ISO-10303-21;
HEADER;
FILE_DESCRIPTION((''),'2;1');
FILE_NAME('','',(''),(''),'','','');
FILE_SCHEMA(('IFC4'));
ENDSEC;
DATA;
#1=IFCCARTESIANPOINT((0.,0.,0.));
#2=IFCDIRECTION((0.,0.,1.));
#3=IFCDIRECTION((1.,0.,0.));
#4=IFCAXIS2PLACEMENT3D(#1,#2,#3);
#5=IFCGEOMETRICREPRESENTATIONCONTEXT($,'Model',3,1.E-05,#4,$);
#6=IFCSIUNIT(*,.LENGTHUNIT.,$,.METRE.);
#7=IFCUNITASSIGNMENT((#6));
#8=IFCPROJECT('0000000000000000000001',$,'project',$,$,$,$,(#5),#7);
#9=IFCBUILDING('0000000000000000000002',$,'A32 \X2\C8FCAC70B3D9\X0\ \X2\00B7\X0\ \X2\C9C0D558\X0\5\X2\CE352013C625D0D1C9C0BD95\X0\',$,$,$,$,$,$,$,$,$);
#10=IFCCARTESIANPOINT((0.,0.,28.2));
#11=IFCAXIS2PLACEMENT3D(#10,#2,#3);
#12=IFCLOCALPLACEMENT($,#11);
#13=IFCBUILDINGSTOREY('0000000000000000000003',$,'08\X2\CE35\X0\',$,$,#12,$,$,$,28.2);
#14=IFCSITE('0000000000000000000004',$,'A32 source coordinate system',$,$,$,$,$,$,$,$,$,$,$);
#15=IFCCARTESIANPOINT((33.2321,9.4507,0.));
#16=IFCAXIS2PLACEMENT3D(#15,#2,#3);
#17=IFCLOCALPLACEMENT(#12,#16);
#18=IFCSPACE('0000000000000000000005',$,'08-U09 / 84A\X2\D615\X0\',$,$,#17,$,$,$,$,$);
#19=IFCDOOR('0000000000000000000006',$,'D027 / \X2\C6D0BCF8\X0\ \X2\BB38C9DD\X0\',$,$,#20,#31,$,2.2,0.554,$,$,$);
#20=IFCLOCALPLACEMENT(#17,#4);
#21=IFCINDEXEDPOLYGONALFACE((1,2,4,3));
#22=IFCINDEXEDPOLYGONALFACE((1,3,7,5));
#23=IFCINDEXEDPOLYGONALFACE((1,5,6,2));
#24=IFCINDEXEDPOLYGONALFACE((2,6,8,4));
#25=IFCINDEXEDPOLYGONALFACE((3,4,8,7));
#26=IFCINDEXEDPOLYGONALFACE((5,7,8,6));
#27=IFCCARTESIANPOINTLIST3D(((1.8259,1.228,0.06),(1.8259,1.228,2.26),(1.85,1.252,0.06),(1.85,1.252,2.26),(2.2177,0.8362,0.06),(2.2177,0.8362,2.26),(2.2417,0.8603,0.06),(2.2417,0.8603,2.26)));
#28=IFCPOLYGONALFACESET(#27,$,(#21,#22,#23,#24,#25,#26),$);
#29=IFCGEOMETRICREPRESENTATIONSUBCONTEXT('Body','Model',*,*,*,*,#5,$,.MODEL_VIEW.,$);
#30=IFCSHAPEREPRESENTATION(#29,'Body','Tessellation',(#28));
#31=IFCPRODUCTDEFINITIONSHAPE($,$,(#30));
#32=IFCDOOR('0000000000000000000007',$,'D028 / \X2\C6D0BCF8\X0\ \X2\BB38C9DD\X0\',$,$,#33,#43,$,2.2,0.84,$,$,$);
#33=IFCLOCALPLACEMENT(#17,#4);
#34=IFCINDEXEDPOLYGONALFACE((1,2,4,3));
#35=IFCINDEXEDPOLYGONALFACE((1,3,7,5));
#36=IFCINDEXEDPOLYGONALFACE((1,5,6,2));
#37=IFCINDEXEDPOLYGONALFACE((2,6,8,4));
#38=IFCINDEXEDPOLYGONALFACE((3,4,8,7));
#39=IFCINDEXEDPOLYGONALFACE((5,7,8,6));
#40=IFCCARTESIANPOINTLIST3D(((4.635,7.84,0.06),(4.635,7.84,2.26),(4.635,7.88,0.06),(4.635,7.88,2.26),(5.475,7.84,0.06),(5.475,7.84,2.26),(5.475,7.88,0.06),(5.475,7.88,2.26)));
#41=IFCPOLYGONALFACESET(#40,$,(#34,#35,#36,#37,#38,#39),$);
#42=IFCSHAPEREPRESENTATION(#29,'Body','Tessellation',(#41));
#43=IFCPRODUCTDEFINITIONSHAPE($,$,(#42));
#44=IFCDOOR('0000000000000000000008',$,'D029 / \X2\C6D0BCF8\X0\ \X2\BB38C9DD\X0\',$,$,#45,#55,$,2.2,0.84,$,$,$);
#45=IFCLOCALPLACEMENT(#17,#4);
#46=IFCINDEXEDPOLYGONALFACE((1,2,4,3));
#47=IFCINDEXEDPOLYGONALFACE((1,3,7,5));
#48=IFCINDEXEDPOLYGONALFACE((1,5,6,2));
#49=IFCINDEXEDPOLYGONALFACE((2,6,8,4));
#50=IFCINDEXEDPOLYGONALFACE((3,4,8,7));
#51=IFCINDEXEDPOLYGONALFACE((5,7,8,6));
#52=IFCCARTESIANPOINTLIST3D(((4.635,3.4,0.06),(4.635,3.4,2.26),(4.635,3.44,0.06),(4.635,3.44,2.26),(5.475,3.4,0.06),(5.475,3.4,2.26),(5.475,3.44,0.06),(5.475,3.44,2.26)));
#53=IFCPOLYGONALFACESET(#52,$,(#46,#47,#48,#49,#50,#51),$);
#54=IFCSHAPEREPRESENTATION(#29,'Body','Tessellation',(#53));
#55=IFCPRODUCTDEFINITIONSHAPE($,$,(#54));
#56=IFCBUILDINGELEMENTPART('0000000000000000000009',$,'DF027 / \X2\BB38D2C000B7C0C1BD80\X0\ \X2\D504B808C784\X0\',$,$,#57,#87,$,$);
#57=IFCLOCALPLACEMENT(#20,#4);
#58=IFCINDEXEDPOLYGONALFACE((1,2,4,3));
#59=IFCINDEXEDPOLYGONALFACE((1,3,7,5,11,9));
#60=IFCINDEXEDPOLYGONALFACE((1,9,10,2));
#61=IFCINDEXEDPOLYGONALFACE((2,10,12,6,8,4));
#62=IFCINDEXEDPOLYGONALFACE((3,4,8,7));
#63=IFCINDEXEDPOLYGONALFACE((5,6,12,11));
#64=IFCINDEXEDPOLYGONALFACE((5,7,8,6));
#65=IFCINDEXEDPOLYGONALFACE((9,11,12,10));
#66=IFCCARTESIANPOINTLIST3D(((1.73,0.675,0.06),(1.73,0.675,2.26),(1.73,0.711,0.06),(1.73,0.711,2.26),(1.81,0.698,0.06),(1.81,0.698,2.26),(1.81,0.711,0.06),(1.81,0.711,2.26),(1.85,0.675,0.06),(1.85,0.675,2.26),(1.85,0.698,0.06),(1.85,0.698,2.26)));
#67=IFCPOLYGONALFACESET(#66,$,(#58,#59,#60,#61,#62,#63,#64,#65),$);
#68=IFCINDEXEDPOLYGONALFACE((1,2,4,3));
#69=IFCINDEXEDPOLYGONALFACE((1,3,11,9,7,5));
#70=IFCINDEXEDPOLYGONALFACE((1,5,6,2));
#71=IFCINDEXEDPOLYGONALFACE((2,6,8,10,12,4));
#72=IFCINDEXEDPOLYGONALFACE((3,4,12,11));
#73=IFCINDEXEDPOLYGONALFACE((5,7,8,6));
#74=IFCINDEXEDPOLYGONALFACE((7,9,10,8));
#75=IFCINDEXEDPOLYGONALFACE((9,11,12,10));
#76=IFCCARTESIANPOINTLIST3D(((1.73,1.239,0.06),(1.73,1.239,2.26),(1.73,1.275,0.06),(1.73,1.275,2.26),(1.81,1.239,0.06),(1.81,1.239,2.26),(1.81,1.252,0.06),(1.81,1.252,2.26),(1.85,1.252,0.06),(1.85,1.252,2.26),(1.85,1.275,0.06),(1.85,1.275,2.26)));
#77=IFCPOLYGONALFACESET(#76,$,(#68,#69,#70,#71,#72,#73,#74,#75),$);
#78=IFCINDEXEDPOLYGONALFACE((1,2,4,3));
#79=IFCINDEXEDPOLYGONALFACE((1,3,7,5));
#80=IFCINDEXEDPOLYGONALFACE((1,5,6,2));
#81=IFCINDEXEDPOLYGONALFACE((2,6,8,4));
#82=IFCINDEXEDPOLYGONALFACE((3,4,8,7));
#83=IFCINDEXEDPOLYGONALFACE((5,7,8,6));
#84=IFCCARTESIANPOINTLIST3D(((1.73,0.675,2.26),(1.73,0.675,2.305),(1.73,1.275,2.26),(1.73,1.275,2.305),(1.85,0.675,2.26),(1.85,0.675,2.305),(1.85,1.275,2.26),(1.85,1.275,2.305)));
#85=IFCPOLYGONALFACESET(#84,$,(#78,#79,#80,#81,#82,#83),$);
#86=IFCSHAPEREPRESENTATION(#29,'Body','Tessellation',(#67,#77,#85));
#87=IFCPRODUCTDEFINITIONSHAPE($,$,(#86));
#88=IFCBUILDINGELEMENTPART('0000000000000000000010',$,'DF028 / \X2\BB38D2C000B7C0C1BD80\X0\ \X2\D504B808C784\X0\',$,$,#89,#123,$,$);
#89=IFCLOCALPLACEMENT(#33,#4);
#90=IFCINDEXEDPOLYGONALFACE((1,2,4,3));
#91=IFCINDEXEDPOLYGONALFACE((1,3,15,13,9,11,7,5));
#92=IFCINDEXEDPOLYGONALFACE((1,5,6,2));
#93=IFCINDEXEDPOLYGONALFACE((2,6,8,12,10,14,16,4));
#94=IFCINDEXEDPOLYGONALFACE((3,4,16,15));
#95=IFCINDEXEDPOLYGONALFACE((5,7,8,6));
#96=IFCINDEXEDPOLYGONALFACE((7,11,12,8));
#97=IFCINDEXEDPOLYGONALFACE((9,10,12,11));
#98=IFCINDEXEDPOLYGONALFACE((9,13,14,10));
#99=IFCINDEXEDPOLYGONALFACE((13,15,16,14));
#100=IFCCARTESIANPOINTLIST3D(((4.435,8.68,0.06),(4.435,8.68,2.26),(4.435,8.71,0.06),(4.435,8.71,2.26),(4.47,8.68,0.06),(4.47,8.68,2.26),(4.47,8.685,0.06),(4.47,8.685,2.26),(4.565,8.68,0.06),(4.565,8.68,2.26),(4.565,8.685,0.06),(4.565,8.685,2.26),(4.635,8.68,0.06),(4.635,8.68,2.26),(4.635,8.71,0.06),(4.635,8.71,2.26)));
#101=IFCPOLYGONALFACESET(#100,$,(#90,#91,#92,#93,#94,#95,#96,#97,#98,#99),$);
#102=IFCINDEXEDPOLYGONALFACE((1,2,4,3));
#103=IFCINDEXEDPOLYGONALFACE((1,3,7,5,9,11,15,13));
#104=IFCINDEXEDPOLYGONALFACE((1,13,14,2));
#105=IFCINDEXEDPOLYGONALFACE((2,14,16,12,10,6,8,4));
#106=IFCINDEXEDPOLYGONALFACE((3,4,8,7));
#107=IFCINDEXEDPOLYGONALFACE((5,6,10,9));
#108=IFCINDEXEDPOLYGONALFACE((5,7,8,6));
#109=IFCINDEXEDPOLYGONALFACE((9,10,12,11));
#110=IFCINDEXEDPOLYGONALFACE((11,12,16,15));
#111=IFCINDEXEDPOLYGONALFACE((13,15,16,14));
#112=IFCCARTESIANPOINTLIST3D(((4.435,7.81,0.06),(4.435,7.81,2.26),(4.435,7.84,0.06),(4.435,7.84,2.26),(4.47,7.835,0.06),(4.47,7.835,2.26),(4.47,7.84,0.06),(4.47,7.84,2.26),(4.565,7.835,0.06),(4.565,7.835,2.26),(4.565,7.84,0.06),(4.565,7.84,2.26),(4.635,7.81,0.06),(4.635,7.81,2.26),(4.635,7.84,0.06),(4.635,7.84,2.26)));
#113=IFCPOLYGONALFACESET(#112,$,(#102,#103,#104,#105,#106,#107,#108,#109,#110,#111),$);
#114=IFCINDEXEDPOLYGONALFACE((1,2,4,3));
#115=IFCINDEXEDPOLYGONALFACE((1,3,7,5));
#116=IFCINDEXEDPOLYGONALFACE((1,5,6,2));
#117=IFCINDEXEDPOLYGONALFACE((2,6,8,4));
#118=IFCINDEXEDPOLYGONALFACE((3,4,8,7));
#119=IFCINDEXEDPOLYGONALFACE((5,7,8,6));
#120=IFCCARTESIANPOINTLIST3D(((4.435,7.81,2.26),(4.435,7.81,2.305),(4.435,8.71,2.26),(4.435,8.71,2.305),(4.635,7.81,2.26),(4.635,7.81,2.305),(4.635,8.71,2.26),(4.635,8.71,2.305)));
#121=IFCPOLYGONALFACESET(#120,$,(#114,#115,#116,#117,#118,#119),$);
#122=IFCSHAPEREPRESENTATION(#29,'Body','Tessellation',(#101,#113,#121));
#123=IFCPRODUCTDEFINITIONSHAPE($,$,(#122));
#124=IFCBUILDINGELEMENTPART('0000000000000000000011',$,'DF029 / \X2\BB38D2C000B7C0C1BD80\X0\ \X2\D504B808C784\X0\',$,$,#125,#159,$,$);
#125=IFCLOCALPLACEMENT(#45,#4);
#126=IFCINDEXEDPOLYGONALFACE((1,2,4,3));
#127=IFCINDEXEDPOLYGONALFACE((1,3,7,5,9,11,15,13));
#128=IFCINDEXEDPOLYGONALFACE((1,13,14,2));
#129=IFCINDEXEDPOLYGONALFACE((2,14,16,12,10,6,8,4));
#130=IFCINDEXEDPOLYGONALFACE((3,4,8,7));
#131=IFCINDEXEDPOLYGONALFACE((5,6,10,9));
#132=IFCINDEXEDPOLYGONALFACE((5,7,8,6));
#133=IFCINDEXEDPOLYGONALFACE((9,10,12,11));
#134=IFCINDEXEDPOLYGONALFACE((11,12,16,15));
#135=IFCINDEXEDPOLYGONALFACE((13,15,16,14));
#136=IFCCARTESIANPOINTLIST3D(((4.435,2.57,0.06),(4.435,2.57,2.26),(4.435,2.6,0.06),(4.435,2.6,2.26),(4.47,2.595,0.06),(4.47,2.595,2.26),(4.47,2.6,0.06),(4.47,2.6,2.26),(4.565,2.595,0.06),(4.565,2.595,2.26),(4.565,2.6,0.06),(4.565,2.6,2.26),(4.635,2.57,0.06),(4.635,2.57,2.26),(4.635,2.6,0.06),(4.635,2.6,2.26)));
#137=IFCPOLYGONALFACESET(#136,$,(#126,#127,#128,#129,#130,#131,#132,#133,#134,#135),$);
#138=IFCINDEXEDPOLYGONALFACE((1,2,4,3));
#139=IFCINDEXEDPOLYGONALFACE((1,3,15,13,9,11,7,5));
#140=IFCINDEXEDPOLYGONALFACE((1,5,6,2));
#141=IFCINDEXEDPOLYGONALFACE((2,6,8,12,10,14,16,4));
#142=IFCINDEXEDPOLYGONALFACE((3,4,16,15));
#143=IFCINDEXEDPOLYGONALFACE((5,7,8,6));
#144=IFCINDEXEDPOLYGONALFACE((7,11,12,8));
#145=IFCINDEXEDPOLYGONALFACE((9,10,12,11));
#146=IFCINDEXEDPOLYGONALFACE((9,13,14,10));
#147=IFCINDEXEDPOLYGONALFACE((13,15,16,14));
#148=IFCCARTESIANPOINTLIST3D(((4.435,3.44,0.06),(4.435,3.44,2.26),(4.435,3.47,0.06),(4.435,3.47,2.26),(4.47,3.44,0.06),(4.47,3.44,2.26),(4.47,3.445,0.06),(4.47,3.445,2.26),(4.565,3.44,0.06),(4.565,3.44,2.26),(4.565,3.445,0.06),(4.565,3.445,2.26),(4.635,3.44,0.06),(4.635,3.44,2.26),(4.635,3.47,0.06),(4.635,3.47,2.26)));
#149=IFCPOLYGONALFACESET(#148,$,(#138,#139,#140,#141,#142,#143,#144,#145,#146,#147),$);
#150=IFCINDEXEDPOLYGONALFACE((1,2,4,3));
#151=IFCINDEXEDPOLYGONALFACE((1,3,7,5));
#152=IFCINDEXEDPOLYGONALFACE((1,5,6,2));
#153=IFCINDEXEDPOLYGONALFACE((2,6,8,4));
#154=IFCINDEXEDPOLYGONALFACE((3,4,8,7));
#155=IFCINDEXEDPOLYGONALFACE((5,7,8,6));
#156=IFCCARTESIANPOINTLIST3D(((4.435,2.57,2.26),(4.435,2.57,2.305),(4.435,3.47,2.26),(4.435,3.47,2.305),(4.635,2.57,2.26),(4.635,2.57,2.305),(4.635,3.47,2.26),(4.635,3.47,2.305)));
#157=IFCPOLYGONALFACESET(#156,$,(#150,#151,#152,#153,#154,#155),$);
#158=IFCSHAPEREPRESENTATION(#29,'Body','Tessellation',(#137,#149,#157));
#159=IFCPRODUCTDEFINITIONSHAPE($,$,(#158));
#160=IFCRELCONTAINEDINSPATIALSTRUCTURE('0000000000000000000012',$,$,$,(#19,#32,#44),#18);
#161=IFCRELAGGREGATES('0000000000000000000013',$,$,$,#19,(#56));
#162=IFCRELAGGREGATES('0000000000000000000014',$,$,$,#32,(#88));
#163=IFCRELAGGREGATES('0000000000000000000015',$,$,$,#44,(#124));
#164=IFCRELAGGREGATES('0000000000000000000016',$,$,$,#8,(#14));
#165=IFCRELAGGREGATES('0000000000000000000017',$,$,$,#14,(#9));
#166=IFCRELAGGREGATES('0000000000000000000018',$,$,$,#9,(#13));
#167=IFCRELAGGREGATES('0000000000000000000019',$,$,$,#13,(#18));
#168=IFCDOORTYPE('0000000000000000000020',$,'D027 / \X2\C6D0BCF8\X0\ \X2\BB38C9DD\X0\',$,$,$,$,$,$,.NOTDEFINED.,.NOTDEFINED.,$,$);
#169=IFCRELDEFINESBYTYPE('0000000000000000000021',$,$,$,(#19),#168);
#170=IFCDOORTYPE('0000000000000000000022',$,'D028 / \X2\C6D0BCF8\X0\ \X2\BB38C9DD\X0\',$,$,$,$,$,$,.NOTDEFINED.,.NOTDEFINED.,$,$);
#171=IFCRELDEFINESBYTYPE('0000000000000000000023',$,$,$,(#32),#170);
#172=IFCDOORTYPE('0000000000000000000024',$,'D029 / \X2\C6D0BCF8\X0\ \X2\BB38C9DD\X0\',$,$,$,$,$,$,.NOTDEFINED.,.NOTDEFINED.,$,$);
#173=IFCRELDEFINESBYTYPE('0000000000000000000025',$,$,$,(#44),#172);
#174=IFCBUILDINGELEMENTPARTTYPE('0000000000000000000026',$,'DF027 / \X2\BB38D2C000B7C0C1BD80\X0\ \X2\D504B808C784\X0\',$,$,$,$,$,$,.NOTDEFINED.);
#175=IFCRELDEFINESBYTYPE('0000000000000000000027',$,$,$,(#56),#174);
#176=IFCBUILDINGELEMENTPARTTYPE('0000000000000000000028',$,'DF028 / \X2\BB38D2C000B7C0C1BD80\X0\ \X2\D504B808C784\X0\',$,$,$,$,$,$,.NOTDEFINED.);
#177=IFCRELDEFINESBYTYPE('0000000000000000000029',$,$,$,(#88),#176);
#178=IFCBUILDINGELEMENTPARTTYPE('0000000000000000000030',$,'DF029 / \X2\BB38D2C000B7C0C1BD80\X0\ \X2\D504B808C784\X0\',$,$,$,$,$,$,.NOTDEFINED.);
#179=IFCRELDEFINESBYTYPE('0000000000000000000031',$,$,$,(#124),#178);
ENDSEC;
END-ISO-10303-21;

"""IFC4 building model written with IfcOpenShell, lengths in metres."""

from ifc_helpers import new_model, si_unit, frame, origin, origin_with_axes, place, context, subcontext, project, spatial, polyline, outline, extrude, source, transform, mapped, type_object, type_shapes, element, aggregate, save


model = new_model("IFC4")

# Units and contexts
model_context = context("Model", 3, precision=1e-05, world=origin_with_axes())
body_context = subcontext(model_context, "Body", "Model", "MODEL_VIEW")
ifc_project = project(units=[si_unit("LENGTHUNIT", "METRE")], contexts=[model_context])

# Site, building, storey, space
storey_placement = place(None, frame((0.0, 0.0, 28.2), z_axis=(0.0, 0.0, 1.0), x_axis=(1.0, 0.0, 0.0)))
space_placement = place(storey_placement, frame((33.2321, 9.4507, 0.0), z_axis=(0.0, 0.0, 1.0), x_axis=(1.0, 0.0, 0.0)))
site = spatial("IfcSite", under=ifc_project, Name="A32 source coordinate system")
building = spatial("IfcBuilding", under=site, Name="A32 주거동 · 지하5층–옥탑지붕")
storey = spatial("IfcBuildingStorey", under=building, at=storey_placement, Name="08층", Elevation=28.2)
space = spatial("IfcSpace", under=storey, at=space_placement, Name="08-U09 / 84A형")

# Doors
door_type_1 = type_object("IfcDoorType", Name="D027 / 원본 문짝", OperationType="NOTDEFINED", PredefinedType="NOTDEFINED")
shared_shape_1 = source(origin(), body_context, "Body", "SweptSolid", [
    extrude(outline(polyline([(1.85, 1.252), (2.2417, 0.8603), (2.2177, 0.8362), (1.8259, 1.228), (1.85, 1.252)])), frame((0.0, 0.0, 0.06)), (0.0, 0.0, 1.0), 2.2),
])
type_shapes(door_type_1, [shared_shape_1])
door_1_placement = place(space_placement, origin_with_axes())
door_1 = element("IfcDoor", 1, at=door_1_placement, inside=space, type_object=door_type_1, Name="D027 / 원본 문짝", OverallHeight=2.2, OverallWidth=0.554, context=body_context, shape_type="MappedRepresentation", body=[
    mapped(shared_shape_1, transform((0.0, 0.0, 0.0), scale=1.0)),
])
door_type_2 = type_object("IfcDoorType", Name="D028 / 원본 문짝", OperationType="NOTDEFINED", PredefinedType="NOTDEFINED")
shared_shape_2 = source(origin(), body_context, "Body", "SweptSolid", [
    extrude(outline(polyline([(5.475, 7.88), (5.475, 7.84), (4.635, 7.84), (4.635, 7.88), (5.475, 7.88)])), frame((0.0, 0.0, 0.06)), (0.0, 0.0, 1.0), 2.2),
])
type_shapes(door_type_2, [shared_shape_2])
door_2_placement = place(space_placement, origin_with_axes())
door_2 = element("IfcDoor", 2, at=door_2_placement, inside=space, type_object=door_type_2, Name="D028 / 원본 문짝", OverallHeight=2.2, OverallWidth=0.84, context=body_context, shape_type="MappedRepresentation", body=[
    mapped(shared_shape_2, transform((0.0, 0.0, 0.0), scale=1.0)),
])
door_type_3 = type_object("IfcDoorType", Name="D029 / 원본 문짝", OperationType="NOTDEFINED", PredefinedType="NOTDEFINED")
shared_shape_3 = source(origin(), body_context, "Body", "SweptSolid", [
    extrude(outline(polyline([(4.635, 3.44), (5.475, 3.44), (5.475, 3.4), (4.635, 3.4), (4.635, 3.44)])), frame((0.0, 0.0, 0.06)), (0.0, 0.0, 1.0), 2.2),
])
type_shapes(door_type_3, [shared_shape_3])
door_3_placement = place(space_placement, origin_with_axes())
door_3 = element("IfcDoor", 3, at=door_3_placement, inside=space, type_object=door_type_3, Name="D029 / 원본 문짝", OverallHeight=2.2, OverallWidth=0.84, context=body_context, shape_type="MappedRepresentation", body=[
    mapped(shared_shape_3, transform((0.0, 0.0, 0.0), scale=1.0)),
])

# Building element parts
building_element_part_type_1 = type_object("IfcBuildingElementPartType", Name="DF027 / 문틀·상부 프레임", PredefinedType="NOTDEFINED")
shared_shape_4 = source(origin(), body_context, "Body", "SweptSolid", [
    extrude(outline(polyline([(1.73, 0.711), (1.81, 0.711), (1.81, 0.698), (1.85, 0.698), (1.85, 0.675), (1.73, 0.675), (1.73, 0.711)])), frame((0.0, 0.0, 0.06)), (0.0, 0.0, 1.0), 2.2),
    extrude(outline(polyline([(1.85, 1.275), (1.85, 1.252), (1.81, 1.252), (1.81, 1.239), (1.73, 1.239), (1.73, 1.275), (1.85, 1.275)])), frame((0.0, 0.0, 0.06)), (0.0, 0.0, 1.0), 2.2),
    extrude(outline(polyline([(1.73, 0.675), (1.73, 1.275), (1.85, 1.275), (1.85, 0.675), (1.73, 0.675)])), frame((0.0, 0.0, 2.26)), (0.0, 0.0, 1.0), 0.045),
])
type_shapes(building_element_part_type_1, [shared_shape_4])
building_element_part_1_placement = place(door_1_placement, origin_with_axes())
building_element_part_1 = element("IfcBuildingElementPart", 4, at=building_element_part_1_placement, type_object=building_element_part_type_1, Name="DF027 / 문틀·상부 프레임", context=body_context, shape_type="MappedRepresentation", body=[
    mapped(shared_shape_4, transform((0.0, 0.0, 0.0), scale=1.0)),
])
aggregate(door_1, [building_element_part_1])
building_element_part_type_2 = type_object("IfcBuildingElementPartType", Name="DF028 / 문틀·상부 프레임", PredefinedType="NOTDEFINED")
shared_shape_5 = source(origin(), body_context, "Body", "SweptSolid", [
    extrude(outline(polyline([(4.635, 8.68), (4.565, 8.68), (4.565, 8.685), (4.47, 8.685), (4.47, 8.68), (4.435, 8.68), (4.435, 8.71), (4.635, 8.71), (4.635, 8.68)])), frame((0.0, 0.0, 0.06)), (0.0, 0.0, 1.0), 2.2),
    extrude(outline(polyline([(4.435, 7.81), (4.435, 7.84), (4.47, 7.84), (4.47, 7.835), (4.565, 7.835), (4.565, 7.84), (4.635, 7.84), (4.635, 7.81), (4.435, 7.81)])), frame((0.0, 0.0, 0.06)), (0.0, 0.0, 1.0), 2.2),
    extrude(outline(polyline([(4.435, 7.81), (4.435, 8.71), (4.635, 8.71), (4.635, 7.81), (4.435, 7.81)])), frame((0.0, 0.0, 2.26)), (0.0, 0.0, 1.0), 0.045),
])
type_shapes(building_element_part_type_2, [shared_shape_5])
building_element_part_2_placement = place(door_2_placement, origin_with_axes())
building_element_part_2 = element("IfcBuildingElementPart", 5, at=building_element_part_2_placement, type_object=building_element_part_type_2, Name="DF028 / 문틀·상부 프레임", context=body_context, shape_type="MappedRepresentation", body=[
    mapped(shared_shape_5, transform((0.0, 0.0, 0.0), scale=1.0)),
])
aggregate(door_2, [building_element_part_2])
building_element_part_type_3 = type_object("IfcBuildingElementPartType", Name="DF029 / 문틀·상부 프레임", PredefinedType="NOTDEFINED")
shared_shape_6 = source(origin(), body_context, "Body", "SweptSolid", [
    extrude(outline(polyline([(4.435, 2.57), (4.435, 2.6), (4.47, 2.6), (4.47, 2.595), (4.565, 2.595), (4.565, 2.6), (4.635, 2.6), (4.635, 2.57), (4.435, 2.57)])), frame((0.0, 0.0, 0.06)), (0.0, 0.0, 1.0), 2.2),
    extrude(outline(polyline([(4.635, 3.44), (4.565, 3.44), (4.565, 3.445), (4.47, 3.445), (4.47, 3.44), (4.435, 3.44), (4.435, 3.47), (4.635, 3.47), (4.635, 3.44)])), frame((0.0, 0.0, 0.06)), (0.0, 0.0, 1.0), 2.2),
    extrude(outline(polyline([(4.435, 2.57), (4.435, 3.47), (4.635, 3.47), (4.635, 2.57), (4.435, 2.57)])), frame((0.0, 0.0, 2.26)), (0.0, 0.0, 1.0), 0.045),
])
type_shapes(building_element_part_type_3, [shared_shape_6])
building_element_part_3_placement = place(door_3_placement, origin_with_axes())
building_element_part_3 = element("IfcBuildingElementPart", 6, at=building_element_part_3_placement, type_object=building_element_part_type_3, Name="DF029 / 문틀·상부 프레임", context=body_context, shape_type="MappedRepresentation", body=[
    mapped(shared_shape_6, transform((0.0, 0.0, 0.0), scale=1.0)),
])
aggregate(door_3, [building_element_part_3])

save(model, "model.ifc")
